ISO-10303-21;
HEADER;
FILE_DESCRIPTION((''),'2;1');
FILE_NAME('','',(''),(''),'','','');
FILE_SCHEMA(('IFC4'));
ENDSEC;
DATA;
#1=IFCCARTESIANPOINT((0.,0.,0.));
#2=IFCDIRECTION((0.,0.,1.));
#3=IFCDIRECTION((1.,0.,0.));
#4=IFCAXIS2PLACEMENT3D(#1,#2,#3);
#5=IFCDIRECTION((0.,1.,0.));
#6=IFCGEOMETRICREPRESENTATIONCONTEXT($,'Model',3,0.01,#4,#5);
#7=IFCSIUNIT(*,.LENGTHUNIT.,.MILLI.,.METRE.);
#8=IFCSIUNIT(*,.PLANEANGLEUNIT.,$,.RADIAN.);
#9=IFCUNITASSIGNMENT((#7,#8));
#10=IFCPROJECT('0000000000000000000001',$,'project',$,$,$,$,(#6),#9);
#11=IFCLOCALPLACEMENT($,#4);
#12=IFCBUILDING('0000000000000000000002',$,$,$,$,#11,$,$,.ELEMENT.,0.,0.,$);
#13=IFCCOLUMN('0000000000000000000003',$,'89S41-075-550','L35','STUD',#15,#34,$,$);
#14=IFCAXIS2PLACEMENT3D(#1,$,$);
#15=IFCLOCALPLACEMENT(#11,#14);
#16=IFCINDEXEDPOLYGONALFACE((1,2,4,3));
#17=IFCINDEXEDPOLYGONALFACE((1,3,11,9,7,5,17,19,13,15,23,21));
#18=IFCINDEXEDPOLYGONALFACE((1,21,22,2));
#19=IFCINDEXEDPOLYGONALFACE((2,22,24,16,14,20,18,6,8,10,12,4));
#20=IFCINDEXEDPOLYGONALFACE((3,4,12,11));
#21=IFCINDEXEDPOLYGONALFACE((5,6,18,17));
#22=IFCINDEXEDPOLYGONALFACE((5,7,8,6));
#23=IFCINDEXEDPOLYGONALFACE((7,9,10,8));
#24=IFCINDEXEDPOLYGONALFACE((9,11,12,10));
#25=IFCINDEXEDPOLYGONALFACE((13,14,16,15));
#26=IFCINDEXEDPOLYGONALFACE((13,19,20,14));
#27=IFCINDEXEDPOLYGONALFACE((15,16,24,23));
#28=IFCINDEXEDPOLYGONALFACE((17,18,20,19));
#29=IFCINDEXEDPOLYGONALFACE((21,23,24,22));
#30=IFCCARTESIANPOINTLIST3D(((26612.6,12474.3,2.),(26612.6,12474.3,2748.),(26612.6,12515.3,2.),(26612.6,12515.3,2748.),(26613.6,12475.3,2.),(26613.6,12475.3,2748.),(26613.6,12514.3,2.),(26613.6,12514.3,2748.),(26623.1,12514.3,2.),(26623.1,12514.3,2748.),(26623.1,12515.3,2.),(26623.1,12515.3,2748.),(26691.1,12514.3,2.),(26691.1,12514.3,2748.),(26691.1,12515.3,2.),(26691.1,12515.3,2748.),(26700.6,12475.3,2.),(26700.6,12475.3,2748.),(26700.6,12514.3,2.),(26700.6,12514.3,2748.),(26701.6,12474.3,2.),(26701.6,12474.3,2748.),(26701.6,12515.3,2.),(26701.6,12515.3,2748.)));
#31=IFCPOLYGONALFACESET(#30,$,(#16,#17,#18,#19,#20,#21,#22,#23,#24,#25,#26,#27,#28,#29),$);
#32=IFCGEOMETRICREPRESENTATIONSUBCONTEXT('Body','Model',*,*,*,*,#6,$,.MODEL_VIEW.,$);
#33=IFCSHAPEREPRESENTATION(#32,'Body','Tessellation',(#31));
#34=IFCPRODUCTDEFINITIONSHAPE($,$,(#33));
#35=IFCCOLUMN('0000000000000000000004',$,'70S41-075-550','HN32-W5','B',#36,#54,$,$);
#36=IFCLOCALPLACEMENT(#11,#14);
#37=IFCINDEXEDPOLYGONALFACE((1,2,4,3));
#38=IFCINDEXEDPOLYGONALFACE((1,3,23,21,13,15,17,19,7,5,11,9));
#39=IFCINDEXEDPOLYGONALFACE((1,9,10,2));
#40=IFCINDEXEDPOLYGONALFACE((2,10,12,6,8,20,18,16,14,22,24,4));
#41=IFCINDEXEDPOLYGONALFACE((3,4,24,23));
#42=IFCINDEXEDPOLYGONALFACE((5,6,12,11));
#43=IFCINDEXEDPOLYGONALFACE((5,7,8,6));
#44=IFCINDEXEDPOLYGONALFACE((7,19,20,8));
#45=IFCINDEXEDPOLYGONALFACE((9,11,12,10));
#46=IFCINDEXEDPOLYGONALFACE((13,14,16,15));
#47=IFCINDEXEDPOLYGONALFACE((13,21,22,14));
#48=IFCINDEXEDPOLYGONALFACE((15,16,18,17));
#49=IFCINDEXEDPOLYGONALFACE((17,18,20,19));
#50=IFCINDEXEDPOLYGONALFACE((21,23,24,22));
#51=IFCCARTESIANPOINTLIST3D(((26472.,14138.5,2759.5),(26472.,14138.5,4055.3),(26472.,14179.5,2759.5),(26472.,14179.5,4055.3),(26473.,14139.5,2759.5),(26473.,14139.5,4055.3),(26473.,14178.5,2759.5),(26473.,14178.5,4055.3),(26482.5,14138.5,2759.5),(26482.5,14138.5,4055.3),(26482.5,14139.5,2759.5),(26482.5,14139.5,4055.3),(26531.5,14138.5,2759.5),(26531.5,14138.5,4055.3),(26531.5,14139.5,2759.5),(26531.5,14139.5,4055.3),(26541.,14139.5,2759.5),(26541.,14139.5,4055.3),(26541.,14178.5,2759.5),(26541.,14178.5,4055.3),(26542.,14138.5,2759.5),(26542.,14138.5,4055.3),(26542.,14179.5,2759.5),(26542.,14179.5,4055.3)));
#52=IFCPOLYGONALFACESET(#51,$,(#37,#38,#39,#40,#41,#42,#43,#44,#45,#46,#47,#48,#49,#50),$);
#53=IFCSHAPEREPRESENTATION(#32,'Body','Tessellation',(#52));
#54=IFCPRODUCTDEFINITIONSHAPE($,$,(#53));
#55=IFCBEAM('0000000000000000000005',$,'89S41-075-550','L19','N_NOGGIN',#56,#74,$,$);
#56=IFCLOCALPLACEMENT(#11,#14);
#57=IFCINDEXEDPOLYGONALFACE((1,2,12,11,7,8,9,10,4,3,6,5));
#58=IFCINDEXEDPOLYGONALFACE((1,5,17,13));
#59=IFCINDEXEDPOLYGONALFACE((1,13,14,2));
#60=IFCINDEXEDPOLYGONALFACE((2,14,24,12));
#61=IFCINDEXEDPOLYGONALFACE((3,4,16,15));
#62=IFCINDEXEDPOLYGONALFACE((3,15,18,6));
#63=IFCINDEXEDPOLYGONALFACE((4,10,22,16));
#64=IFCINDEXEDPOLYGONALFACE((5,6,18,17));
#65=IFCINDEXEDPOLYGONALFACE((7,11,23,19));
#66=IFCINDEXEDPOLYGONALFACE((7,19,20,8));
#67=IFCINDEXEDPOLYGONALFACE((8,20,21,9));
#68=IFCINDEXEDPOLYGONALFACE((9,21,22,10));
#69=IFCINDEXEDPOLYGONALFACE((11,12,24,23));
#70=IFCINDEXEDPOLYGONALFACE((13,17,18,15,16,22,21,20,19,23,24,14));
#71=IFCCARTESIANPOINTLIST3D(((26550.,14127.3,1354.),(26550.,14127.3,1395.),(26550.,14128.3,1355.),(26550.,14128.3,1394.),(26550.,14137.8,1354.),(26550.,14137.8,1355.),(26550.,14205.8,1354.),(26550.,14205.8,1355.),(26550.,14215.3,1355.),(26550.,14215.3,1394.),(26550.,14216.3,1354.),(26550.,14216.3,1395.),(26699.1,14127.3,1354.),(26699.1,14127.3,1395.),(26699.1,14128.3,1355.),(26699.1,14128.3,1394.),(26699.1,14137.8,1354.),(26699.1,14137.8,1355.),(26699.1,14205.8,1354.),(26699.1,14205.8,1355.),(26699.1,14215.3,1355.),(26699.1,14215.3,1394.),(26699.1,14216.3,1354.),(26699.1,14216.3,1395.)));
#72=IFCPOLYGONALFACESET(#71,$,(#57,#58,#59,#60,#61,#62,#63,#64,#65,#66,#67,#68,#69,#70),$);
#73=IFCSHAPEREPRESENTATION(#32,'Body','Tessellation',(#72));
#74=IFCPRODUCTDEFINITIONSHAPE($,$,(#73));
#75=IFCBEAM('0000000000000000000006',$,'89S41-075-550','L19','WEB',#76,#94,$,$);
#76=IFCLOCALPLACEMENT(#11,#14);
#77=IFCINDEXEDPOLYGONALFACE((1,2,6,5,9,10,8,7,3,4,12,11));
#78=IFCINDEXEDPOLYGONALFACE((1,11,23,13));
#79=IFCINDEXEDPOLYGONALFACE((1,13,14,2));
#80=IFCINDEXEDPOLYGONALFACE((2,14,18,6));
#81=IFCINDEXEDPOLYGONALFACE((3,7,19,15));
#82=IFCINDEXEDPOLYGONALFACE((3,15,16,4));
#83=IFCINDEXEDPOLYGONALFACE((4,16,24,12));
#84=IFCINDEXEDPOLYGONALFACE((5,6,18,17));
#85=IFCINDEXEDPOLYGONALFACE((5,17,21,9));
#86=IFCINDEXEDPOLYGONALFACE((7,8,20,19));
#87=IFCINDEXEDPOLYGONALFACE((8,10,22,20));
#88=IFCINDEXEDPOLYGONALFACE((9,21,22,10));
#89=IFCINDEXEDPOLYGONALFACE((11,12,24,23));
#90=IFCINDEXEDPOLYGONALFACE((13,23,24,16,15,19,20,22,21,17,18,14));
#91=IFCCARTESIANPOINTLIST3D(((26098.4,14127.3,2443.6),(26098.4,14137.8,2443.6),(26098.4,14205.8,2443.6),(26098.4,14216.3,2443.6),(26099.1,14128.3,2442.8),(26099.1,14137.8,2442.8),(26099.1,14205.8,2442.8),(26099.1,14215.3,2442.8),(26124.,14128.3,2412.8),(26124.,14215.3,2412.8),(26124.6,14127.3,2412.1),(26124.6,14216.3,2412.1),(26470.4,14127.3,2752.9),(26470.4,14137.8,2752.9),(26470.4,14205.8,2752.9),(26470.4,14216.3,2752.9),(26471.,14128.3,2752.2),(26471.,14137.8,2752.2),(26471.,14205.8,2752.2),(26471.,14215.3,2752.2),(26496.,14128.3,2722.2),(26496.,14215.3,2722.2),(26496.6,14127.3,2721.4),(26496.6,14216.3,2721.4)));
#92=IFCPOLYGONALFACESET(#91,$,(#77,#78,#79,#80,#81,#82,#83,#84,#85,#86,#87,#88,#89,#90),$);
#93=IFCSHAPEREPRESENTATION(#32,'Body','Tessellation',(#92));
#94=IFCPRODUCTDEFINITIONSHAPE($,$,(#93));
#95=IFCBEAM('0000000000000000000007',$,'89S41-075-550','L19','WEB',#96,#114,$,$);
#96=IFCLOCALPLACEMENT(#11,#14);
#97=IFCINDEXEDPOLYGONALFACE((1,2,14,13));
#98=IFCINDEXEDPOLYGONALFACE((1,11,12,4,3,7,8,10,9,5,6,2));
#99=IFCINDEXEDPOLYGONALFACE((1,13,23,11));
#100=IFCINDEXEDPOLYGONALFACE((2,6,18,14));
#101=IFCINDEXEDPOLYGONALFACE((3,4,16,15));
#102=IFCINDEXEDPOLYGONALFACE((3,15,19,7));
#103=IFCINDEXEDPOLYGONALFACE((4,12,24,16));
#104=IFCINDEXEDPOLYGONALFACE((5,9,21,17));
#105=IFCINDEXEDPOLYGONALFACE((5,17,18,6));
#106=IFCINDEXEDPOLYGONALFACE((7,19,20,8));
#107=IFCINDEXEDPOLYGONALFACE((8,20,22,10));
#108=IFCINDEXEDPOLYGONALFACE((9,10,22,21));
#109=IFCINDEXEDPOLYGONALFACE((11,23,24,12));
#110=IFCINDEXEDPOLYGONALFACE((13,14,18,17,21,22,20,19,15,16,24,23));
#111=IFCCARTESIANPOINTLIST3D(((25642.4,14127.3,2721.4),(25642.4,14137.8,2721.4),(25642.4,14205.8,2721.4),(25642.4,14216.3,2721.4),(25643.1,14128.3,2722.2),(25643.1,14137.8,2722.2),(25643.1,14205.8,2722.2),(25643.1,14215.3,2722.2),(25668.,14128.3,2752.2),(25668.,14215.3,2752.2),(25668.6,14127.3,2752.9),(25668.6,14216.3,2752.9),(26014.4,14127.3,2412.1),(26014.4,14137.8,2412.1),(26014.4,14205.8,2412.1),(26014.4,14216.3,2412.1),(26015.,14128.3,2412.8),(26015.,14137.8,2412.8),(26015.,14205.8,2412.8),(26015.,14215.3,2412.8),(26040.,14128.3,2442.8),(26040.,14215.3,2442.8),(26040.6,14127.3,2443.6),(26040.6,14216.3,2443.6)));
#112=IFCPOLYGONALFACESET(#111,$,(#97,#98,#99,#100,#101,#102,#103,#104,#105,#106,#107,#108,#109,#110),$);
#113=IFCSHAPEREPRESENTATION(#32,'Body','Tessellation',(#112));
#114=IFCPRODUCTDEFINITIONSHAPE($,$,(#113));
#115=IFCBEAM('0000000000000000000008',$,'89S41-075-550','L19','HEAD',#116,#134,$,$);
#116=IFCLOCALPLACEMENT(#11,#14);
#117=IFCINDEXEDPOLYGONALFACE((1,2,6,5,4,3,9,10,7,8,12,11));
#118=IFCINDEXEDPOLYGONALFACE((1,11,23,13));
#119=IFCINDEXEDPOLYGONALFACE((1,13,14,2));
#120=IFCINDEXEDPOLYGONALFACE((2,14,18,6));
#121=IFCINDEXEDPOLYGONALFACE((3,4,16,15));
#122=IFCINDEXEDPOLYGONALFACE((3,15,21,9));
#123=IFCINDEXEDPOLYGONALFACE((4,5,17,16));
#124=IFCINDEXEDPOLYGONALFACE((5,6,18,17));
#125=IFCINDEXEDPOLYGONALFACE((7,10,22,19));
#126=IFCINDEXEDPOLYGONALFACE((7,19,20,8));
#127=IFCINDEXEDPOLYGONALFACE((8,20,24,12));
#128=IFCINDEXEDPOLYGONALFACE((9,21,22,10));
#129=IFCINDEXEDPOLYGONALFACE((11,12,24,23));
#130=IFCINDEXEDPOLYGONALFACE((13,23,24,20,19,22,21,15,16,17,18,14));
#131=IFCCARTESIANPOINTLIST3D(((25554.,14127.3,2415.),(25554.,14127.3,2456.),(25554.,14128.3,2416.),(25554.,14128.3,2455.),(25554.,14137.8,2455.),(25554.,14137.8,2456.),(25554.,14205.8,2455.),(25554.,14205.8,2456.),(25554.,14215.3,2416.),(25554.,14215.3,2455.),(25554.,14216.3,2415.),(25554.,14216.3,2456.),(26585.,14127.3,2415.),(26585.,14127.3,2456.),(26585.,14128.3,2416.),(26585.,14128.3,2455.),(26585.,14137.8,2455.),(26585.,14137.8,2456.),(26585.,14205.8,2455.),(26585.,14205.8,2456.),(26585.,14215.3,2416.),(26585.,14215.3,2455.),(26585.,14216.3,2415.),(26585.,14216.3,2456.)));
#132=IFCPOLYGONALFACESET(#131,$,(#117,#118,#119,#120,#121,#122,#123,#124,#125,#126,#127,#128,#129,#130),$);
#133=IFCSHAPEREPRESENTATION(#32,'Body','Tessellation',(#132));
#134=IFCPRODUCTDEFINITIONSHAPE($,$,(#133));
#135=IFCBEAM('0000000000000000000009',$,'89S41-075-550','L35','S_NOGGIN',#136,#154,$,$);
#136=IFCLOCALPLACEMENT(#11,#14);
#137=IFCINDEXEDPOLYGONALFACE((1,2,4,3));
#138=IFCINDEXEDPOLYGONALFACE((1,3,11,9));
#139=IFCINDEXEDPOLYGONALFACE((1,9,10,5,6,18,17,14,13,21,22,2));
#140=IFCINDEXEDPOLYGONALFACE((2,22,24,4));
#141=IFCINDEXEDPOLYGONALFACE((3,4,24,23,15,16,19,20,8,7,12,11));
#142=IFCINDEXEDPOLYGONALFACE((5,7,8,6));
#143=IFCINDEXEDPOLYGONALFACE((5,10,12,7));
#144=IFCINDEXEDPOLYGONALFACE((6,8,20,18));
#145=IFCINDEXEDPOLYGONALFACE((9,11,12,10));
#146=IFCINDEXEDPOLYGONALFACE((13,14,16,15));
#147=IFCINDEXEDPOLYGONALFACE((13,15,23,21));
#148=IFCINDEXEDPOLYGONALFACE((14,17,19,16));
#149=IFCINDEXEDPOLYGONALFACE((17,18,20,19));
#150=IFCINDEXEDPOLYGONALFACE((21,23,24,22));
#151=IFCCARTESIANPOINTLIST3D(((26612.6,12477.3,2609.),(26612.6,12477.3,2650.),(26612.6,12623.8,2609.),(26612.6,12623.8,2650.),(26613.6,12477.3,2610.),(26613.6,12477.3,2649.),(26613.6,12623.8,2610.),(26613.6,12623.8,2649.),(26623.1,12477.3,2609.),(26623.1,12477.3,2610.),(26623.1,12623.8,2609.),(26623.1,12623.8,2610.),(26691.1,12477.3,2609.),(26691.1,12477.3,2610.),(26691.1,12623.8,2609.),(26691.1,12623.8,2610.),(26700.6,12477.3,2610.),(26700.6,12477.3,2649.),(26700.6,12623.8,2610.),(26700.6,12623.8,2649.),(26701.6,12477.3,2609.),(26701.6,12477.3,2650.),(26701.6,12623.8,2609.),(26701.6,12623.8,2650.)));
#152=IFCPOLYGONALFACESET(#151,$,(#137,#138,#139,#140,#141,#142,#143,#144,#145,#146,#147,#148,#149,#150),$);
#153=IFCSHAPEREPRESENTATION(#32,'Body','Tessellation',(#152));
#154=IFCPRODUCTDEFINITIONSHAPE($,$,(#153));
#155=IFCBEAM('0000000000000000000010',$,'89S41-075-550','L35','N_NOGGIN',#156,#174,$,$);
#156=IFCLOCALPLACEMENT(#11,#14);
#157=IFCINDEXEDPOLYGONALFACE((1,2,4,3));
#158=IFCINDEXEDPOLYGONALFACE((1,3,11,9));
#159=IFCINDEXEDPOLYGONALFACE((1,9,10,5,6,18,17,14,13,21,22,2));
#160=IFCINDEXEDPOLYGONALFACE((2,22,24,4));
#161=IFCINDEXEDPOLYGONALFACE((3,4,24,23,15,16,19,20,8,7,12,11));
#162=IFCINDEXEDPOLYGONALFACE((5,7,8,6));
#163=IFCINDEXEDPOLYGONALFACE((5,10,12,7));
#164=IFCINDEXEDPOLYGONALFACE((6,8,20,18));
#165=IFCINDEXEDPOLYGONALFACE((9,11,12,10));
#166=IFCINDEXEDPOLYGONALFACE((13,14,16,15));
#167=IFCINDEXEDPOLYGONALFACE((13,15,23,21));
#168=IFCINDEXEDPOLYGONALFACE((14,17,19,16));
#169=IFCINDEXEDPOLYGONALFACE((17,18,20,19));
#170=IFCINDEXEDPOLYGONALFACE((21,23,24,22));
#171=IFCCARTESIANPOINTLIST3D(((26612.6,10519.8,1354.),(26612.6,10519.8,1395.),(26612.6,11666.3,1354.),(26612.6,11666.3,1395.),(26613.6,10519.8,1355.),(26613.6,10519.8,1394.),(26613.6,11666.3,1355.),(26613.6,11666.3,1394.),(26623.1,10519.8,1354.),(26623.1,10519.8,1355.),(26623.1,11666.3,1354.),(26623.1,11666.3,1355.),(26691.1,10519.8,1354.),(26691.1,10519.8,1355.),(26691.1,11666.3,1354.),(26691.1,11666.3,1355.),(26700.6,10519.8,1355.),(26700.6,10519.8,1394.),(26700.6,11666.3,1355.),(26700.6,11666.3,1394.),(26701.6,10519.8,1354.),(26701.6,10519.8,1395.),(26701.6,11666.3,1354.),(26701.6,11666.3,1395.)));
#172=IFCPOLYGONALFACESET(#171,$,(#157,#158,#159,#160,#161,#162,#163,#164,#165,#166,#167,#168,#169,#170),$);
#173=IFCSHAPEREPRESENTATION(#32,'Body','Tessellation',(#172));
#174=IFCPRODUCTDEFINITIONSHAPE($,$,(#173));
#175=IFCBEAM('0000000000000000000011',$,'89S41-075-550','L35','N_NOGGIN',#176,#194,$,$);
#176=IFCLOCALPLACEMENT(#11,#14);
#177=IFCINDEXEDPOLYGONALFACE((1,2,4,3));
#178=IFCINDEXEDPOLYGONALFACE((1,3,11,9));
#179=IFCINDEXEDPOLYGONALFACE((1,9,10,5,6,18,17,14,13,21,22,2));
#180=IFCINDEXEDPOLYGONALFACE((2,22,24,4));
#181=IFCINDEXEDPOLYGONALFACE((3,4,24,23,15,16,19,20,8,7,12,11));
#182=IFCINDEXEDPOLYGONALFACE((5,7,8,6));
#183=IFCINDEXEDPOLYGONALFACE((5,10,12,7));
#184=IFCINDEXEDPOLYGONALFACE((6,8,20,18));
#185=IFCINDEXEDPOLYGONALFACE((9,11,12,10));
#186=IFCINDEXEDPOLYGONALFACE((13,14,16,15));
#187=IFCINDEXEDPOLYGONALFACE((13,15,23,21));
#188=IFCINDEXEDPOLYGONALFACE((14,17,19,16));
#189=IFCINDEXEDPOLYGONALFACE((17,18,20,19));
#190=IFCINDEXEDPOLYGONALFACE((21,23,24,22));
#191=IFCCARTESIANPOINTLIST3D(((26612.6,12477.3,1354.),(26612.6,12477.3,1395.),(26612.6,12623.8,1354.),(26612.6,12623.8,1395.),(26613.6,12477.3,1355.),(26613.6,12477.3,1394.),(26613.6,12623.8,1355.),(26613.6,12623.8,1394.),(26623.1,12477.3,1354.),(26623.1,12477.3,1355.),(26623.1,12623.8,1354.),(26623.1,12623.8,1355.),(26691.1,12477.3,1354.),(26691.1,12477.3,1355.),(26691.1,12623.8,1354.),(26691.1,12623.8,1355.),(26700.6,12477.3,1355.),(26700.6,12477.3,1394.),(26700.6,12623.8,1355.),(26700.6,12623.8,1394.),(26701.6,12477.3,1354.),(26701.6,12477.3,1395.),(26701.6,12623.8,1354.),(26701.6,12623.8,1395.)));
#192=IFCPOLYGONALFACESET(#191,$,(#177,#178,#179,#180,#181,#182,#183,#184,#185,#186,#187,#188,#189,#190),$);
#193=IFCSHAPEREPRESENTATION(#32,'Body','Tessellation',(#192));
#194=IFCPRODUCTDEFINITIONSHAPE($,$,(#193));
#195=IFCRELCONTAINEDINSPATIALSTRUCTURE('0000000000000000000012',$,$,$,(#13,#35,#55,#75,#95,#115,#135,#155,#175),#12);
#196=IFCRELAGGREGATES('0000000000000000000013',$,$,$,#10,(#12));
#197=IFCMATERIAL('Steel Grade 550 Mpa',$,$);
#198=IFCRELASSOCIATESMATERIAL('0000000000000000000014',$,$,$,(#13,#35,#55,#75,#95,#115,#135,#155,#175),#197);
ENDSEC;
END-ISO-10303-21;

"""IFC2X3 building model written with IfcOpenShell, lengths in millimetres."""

from ifc_helpers import new_model, si_unit, direction, frame, origin, origin_with_axes, origin_2d_with_axis, place, context, subcontext, project, spatial, c_section, extrude, source, transform, mapped, material, element, save


model = new_model("IFC2X3")

# Units and contexts
model_context = context("Model", 3, precision=0.01, world=origin_with_axes(), true_north=direction((0.0, 1.0, 0.0)))
body_context = subcontext(model_context, "Body", "Model", "MODEL_VIEW")
ifc_project = project(units=[si_unit("LENGTHUNIT", "METRE", prefix="MILLI"), si_unit("PLANEANGLEUNIT", "RADIAN")], contexts=[model_context])

# Building
building_placement = place(None, origin_with_axes())
building = spatial("IfcBuilding", under=ifc_project, at=building_placement, CompositionType="ELEMENT", ElevationOfRefHeight=0.0, ElevationOfTerrain=0.0)

# Columns
ifc_material = material(Name="Steel Grade 550 Mpa")
shared_shape_1 = source(origin(), body_context, "Body", "SweptSolid", [
    extrude(c_section(Depth=89.0, Width=41.0, WallThickness=1.0, Girth=10.5, at=origin_2d_with_axis()), origin_with_axes(), (0.0, 0.0, 1.0), 2746.0),
])
column_1_placement = place(None, frame((26657.1, 12494.8, 2.0), z_axis=(0.0, 0.0, 1.0), x_axis=(0.0, 1.0, 0.0)))
element("IfcColumn", 1, at=column_1_placement, inside=building, material=ifc_material, Name="89S41-075-550", Description="L35", ObjectType="STUD", context=body_context, shape_type="MappedRepresentation", body=[
    mapped(shared_shape_1, transform((0.0, 0.0, 0.0), scale=1.0)),
])
shared_shape_2 = source(origin(), body_context, "Body", "SweptSolid", [
    extrude(c_section(Depth=70.0, Width=41.0, WallThickness=1.0, Girth=10.5, at=origin_2d_with_axis()), origin_with_axes(), (0.0, 0.0, 1.0), 1295.8),
])
column_2_placement = place(None, frame((26507.0, 14159.0, 2759.5), z_axis=(0.0, 0.0, 1.0), x_axis=(0.0, -1.0, 0.0)))
element("IfcColumn", 2, at=column_2_placement, inside=building, material=ifc_material, Name="70S41-075-550", Description="HN32-W5", ObjectType="B", context=body_context, shape_type="MappedRepresentation", body=[
    mapped(shared_shape_2, transform((0.0, 0.0, 0.0), scale=1.0)),
])

# Beams
shared_shape_3 = source(origin(), body_context, "Body", "SweptSolid", [
    extrude(c_section(Depth=89.0, Width=41.0, WallThickness=1.0, Girth=10.5, at=origin_2d_with_axis()), origin_with_axes(), (0.0, 0.0, 1.0), 149.0),
])
beam_1_placement = place(None, frame((26550.0, 14171.8, 1374.5), z_axis=(1.0, 0.0, 0.0), x_axis=(0.0, 0.0, -1.0)))
element("IfcBeam", 3, at=beam_1_placement, inside=building, material=ifc_material, Name="89S41-075-550", Description="L19", ObjectType="N_NOGGIN", context=body_context, shape_type="MappedRepresentation", body=[
    mapped(shared_shape_3, transform((0.0, 0.0, 0.0), scale=1.0)),
])
shared_shape_4 = source(origin(), body_context, "Body", "SweptSolid", [
    extrude(c_section(Depth=89.0, Width=41.0, WallThickness=1.0, Girth=10.5, at=origin_2d_with_axis()), origin_with_axes(), (0.0, 0.0, 1.0), 483.8),
])
beam_2_placement = place(None, frame((26111.5, 14171.8, 2427.8), z_axis=(0.768843, 0.0, 0.639437), x_axis=(-0.639437, 0.0, 0.768843)))
element("IfcBeam", 4, at=beam_2_placement, inside=building, material=ifc_material, Name="89S41-075-550", Description="L19", ObjectType="WEB", context=body_context, shape_type="MappedRepresentation", body=[
    mapped(shared_shape_4, transform((0.0, 0.0, 0.0), scale=1.0)),
])
shared_shape_5 = source(origin(), body_context, "Body", "SweptSolid", [
    extrude(c_section(Depth=89.0, Width=41.0, WallThickness=1.0, Girth=10.5, at=origin_2d_with_axis()), origin_with_axes(), (0.0, 0.0, 1.0), 483.8),
])
beam_3_placement = place(None, frame((26027.5, 14171.8, 2427.8), z_axis=(-0.768847, 0.0, 0.639433), x_axis=(-0.639433, 0.0, -0.768847)))
element("IfcBeam", 5, at=beam_3_placement, inside=building, material=ifc_material, Name="89S41-075-550", Description="L19", ObjectType="WEB", context=body_context, shape_type="MappedRepresentation", body=[
    mapped(shared_shape_5, transform((0.0, 0.0, 0.0), scale=1.0)),
])
shared_shape_6 = source(origin(), body_context, "Body", "SweptSolid", [
    extrude(c_section(Depth=89.0, Width=41.0, WallThickness=1.0, Girth=10.5, at=origin_2d_with_axis()), origin_with_axes(), (0.0, 0.0, 1.0), 1031.0),
])
beam_4_placement = place(None, frame((25554.0, 14171.8, 2435.5), z_axis=(1.0, 0.0, 0.0), x_axis=(0.0, 0.0, 1.0)))
element("IfcBeam", 6, at=beam_4_placement, inside=building, material=ifc_material, Name="89S41-075-550", Description="L19", ObjectType="HEAD", context=body_context, shape_type="MappedRepresentation", body=[
    mapped(shared_shape_6, transform((0.0, 0.0, 0.0), scale=1.0)),
])
shared_shape_7 = source(origin(), body_context, "Body", "SweptSolid", [
    extrude(c_section(Depth=89.0, Width=41.0, WallThickness=1.0, Girth=10.5, at=origin_2d_with_axis()), origin_with_axes(), (0.0, 0.0, 1.0), 146.5),
])
beam_5_placement = place(None, frame((26657.1, 12623.8, 2629.5), z_axis=(0.0, -1.0, 0.0), x_axis=(0.0, 0.0, -1.0)))
element("IfcBeam", 7, at=beam_5_placement, inside=building, material=ifc_material, Name="89S41-075-550", Description="L35", ObjectType="S_NOGGIN", context=body_context, shape_type="MappedRepresentation", body=[
    mapped(shared_shape_7, transform((0.0, 0.0, 0.0), scale=1.0)),
])
shared_shape_8 = source(origin(), body_context, "Body", "SweptSolid", [
    extrude(c_section(Depth=89.0, Width=41.0, WallThickness=1.0, Girth=10.5, at=origin_2d_with_axis()), origin_with_axes(), (0.0, 0.0, 1.0), 1146.5),
])
beam_6_placement = place(None, frame((26657.1, 11666.3, 1374.5), z_axis=(0.0, -1.0, 0.0), x_axis=(0.0, 0.0, -1.0)))
element("IfcBeam", 8, at=beam_6_placement, inside=building, material=ifc_material, Name="89S41-075-550", Description="L35", ObjectType="N_NOGGIN", context=body_context, shape_type="MappedRepresentation", body=[
    mapped(shared_shape_8, transform((0.0, 0.0, 0.0), scale=1.0)),
])
shared_shape_9 = source(origin(), body_context, "Body", "SweptSolid", [
    extrude(c_section(Depth=89.0, Width=41.0, WallThickness=1.0, Girth=10.5, at=origin_2d_with_axis()), origin_with_axes(), (0.0, 0.0, 1.0), 146.5),
])
beam_7_placement = place(None, frame((26657.1, 12623.8, 1374.5), z_axis=(0.0, -1.0, 0.0), x_axis=(0.0, 0.0, -1.0)))
element("IfcBeam", 9, at=beam_7_placement, inside=building, material=ifc_material, Name="89S41-075-550", Description="L35", ObjectType="N_NOGGIN", context=body_context, shape_type="MappedRepresentation", body=[
    mapped(shared_shape_9, transform((0.0, 0.0, 0.0), scale=1.0)),
])

save(model, "model.ifc")
